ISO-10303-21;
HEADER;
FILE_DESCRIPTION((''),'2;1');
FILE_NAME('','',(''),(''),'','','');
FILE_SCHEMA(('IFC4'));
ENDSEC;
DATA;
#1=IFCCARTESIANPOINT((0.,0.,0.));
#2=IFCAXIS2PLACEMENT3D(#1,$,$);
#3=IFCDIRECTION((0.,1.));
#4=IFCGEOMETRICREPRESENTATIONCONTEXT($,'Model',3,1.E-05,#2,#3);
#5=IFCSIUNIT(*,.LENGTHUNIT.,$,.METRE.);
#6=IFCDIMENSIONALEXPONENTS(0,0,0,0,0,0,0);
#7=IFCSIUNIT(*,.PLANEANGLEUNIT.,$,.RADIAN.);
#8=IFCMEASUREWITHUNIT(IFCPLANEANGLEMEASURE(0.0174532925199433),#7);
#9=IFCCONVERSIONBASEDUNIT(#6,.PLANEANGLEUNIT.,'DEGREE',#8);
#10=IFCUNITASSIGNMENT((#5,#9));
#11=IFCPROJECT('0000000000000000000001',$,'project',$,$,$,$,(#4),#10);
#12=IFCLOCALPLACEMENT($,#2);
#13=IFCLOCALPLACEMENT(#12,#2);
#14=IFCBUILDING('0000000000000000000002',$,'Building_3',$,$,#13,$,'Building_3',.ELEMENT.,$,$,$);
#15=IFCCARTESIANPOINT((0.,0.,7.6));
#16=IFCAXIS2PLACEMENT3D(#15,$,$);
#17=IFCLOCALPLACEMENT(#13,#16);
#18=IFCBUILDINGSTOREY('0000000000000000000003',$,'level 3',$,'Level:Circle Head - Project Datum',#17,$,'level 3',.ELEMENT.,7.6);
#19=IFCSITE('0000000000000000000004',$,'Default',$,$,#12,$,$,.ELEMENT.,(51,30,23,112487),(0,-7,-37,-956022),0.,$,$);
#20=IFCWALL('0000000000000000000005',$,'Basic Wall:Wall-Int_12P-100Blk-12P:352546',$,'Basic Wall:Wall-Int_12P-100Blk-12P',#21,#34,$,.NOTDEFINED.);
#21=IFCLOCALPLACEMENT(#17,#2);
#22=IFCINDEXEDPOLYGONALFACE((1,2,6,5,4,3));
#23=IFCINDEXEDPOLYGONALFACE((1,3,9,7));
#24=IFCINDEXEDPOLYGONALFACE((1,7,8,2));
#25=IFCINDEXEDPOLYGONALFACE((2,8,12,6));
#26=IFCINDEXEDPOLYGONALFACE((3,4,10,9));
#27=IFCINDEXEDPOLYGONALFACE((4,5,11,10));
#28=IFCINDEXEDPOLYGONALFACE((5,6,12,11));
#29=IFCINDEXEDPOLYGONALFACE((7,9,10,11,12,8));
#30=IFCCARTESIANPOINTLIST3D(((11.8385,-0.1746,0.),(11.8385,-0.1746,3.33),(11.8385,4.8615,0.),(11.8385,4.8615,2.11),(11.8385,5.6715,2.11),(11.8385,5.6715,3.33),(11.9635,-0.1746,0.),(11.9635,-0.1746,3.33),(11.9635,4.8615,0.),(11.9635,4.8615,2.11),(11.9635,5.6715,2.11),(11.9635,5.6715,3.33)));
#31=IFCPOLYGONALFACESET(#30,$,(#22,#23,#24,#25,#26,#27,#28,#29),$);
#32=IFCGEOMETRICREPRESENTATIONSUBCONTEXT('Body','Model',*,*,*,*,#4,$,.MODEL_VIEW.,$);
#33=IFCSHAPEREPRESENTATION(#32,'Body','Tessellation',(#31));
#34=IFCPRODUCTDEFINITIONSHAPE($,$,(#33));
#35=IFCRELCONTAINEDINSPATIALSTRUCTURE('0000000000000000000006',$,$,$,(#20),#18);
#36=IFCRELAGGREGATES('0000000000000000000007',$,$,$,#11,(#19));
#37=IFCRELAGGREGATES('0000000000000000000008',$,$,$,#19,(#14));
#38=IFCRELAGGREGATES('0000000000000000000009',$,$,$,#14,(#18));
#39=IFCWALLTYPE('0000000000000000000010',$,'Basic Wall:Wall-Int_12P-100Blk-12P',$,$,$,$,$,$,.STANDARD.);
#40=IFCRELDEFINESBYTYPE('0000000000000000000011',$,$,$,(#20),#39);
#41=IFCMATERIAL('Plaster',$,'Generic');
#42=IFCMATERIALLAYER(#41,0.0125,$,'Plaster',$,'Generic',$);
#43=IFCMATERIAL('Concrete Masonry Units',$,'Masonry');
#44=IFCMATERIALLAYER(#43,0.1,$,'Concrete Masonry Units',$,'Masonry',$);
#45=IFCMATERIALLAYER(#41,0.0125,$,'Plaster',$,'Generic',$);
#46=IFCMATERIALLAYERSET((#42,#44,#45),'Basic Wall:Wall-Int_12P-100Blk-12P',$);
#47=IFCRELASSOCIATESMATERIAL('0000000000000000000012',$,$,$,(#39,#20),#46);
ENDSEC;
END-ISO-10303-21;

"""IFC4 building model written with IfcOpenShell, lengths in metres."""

from ifc_helpers import new_model, entity, si_unit, converted_unit, direction, frame, frame_2d, origin, place, context, subcontext, project, spatial, polyline, rectangle, extrude, clip, bounded_halfspace, material, layer, layer_set, layer_usage, type_object, element, save


model = new_model("IFC4")

# Units and contexts
model_context = context("Model", 3, precision=1e-05, world=origin(), true_north=direction((0.0, 1.0)))
body_context = subcontext(model_context, "Body", "Model", "MODEL_VIEW")
ifc_project = project(units=[si_unit("LENGTHUNIT", "METRE"), converted_unit("PLANEANGLEUNIT", "DEGREE", entity("IfcPlaneAngleMeasure", 0.0174532925199433), si_unit("PLANEANGLEUNIT", "RADIAN"), dimensions=[0, 0, 0, 0, 0, 0, 0])], contexts=[model_context])

# Site, building, storey
site_placement = place(None, origin())
site = spatial("IfcSite", under=ifc_project, at=site_placement, Name="Default", CompositionType="ELEMENT", RefLatitude=(51, 30, 23, 112487), RefLongitude=(0, -7, -37, -956022), RefElevation=0.0)
building_placement = place(site_placement, origin())
building = spatial("IfcBuilding", under=site, at=building_placement, Name="Building_3", LongName="Building_3", CompositionType="ELEMENT")
storey_placement = place(building_placement, frame((0.0, 0.0, 7.6)))
storey = spatial("IfcBuildingStorey", under=building, at=storey_placement, Name="level 3", ObjectType="Level:Circle Head - Project Datum", LongName="level 3", CompositionType="ELEMENT", Elevation=7.6)

# Wall, opening
ifc_material_1 = material(Name="Plaster", Category="Generic")
ifc_layer_1 = layer(ifc_material_1, 0.0125, Name="Plaster", Category="Generic")
ifc_material_2 = material(Name="Concrete Masonry Units", Category="Masonry")
ifc_layer_2 = layer(ifc_material_2, 0.1, Name="Concrete Masonry Units", Category="Masonry")
ifc_layer_3 = layer(ifc_material_1, 0.0125, Name="Plaster", Category="Generic")
ifc_layer_set = layer_set([ifc_layer_1, ifc_layer_2, ifc_layer_3], Name="Basic Wall:Wall-Int_12P-100Blk-12P")
wall_type = type_object("IfcWallType", Name="Basic Wall:Wall-Int_12P-100Blk-12P", PredefinedType="STANDARD", material=ifc_layer_set)
ifc_layer_usage_1 = layer_usage(ifc_layer_set, "AXIS2", "NEGATIVE", 0.0625)
wall_1_placement = place(storey_placement, frame((11.901, 5.6715, 0.0), z_axis=(0.0, 0.0, 1.0), x_axis=(0.0, -1.0, 0.0)))
wall_1 = element("IfcWall", 1, at=wall_1_placement, inside=storey, type_object=wall_type, material=ifc_layer_usage_1, Name="Basic Wall:Wall-Int_12P-100Blk-12P:352546", ObjectType="Basic Wall:Wall-Int_12P-100Blk-12P", PredefinedType="NOTDEFINED", context=body_context, shape_type="Clipping", body=[
    clip(extrude(rectangle(XDim=5.846, YDim=0.125, at=frame_2d((2.923, 0.0), x_axis=(-1.0, 0.0))), origin(), (0.0, 0.0, 1.0), 3.33), bounded_halfspace(frame((0.0, -0.0625, 3.33), z_axis=(0.0, 0.0, -1.0), x_axis=(-1.0, 0.0, 0.0)), True, frame((0.0, -0.0625, 3.33)), polyline([(0.0, 0.0), (5.846, 0.0), (5.846, 0.125), (0.0, 0.125), (0.0, 0.0)]))),
])
opening_1_placement = place(wall_1_placement, frame((0.0, -0.0625, 0.0)))
element("IfcOpeningElement", 2, at=opening_1_placement, cuts=wall_1, PredefinedType="OPENING", context=body_context, shape_type="SweptSolid", body=[
    extrude(rectangle(XDim=2.11, YDim=0.81, at=frame_2d((1.055, 0.405), x_axis=(1.0, 0.0))), frame((0.0, 0.0, 0.0), z_axis=(0.0, 1.0, 0.0), x_axis=(0.0, 0.0, 1.0)), (0.0, 0.0, 1.0), 0.125),
])

save(model, "model.ifc")
